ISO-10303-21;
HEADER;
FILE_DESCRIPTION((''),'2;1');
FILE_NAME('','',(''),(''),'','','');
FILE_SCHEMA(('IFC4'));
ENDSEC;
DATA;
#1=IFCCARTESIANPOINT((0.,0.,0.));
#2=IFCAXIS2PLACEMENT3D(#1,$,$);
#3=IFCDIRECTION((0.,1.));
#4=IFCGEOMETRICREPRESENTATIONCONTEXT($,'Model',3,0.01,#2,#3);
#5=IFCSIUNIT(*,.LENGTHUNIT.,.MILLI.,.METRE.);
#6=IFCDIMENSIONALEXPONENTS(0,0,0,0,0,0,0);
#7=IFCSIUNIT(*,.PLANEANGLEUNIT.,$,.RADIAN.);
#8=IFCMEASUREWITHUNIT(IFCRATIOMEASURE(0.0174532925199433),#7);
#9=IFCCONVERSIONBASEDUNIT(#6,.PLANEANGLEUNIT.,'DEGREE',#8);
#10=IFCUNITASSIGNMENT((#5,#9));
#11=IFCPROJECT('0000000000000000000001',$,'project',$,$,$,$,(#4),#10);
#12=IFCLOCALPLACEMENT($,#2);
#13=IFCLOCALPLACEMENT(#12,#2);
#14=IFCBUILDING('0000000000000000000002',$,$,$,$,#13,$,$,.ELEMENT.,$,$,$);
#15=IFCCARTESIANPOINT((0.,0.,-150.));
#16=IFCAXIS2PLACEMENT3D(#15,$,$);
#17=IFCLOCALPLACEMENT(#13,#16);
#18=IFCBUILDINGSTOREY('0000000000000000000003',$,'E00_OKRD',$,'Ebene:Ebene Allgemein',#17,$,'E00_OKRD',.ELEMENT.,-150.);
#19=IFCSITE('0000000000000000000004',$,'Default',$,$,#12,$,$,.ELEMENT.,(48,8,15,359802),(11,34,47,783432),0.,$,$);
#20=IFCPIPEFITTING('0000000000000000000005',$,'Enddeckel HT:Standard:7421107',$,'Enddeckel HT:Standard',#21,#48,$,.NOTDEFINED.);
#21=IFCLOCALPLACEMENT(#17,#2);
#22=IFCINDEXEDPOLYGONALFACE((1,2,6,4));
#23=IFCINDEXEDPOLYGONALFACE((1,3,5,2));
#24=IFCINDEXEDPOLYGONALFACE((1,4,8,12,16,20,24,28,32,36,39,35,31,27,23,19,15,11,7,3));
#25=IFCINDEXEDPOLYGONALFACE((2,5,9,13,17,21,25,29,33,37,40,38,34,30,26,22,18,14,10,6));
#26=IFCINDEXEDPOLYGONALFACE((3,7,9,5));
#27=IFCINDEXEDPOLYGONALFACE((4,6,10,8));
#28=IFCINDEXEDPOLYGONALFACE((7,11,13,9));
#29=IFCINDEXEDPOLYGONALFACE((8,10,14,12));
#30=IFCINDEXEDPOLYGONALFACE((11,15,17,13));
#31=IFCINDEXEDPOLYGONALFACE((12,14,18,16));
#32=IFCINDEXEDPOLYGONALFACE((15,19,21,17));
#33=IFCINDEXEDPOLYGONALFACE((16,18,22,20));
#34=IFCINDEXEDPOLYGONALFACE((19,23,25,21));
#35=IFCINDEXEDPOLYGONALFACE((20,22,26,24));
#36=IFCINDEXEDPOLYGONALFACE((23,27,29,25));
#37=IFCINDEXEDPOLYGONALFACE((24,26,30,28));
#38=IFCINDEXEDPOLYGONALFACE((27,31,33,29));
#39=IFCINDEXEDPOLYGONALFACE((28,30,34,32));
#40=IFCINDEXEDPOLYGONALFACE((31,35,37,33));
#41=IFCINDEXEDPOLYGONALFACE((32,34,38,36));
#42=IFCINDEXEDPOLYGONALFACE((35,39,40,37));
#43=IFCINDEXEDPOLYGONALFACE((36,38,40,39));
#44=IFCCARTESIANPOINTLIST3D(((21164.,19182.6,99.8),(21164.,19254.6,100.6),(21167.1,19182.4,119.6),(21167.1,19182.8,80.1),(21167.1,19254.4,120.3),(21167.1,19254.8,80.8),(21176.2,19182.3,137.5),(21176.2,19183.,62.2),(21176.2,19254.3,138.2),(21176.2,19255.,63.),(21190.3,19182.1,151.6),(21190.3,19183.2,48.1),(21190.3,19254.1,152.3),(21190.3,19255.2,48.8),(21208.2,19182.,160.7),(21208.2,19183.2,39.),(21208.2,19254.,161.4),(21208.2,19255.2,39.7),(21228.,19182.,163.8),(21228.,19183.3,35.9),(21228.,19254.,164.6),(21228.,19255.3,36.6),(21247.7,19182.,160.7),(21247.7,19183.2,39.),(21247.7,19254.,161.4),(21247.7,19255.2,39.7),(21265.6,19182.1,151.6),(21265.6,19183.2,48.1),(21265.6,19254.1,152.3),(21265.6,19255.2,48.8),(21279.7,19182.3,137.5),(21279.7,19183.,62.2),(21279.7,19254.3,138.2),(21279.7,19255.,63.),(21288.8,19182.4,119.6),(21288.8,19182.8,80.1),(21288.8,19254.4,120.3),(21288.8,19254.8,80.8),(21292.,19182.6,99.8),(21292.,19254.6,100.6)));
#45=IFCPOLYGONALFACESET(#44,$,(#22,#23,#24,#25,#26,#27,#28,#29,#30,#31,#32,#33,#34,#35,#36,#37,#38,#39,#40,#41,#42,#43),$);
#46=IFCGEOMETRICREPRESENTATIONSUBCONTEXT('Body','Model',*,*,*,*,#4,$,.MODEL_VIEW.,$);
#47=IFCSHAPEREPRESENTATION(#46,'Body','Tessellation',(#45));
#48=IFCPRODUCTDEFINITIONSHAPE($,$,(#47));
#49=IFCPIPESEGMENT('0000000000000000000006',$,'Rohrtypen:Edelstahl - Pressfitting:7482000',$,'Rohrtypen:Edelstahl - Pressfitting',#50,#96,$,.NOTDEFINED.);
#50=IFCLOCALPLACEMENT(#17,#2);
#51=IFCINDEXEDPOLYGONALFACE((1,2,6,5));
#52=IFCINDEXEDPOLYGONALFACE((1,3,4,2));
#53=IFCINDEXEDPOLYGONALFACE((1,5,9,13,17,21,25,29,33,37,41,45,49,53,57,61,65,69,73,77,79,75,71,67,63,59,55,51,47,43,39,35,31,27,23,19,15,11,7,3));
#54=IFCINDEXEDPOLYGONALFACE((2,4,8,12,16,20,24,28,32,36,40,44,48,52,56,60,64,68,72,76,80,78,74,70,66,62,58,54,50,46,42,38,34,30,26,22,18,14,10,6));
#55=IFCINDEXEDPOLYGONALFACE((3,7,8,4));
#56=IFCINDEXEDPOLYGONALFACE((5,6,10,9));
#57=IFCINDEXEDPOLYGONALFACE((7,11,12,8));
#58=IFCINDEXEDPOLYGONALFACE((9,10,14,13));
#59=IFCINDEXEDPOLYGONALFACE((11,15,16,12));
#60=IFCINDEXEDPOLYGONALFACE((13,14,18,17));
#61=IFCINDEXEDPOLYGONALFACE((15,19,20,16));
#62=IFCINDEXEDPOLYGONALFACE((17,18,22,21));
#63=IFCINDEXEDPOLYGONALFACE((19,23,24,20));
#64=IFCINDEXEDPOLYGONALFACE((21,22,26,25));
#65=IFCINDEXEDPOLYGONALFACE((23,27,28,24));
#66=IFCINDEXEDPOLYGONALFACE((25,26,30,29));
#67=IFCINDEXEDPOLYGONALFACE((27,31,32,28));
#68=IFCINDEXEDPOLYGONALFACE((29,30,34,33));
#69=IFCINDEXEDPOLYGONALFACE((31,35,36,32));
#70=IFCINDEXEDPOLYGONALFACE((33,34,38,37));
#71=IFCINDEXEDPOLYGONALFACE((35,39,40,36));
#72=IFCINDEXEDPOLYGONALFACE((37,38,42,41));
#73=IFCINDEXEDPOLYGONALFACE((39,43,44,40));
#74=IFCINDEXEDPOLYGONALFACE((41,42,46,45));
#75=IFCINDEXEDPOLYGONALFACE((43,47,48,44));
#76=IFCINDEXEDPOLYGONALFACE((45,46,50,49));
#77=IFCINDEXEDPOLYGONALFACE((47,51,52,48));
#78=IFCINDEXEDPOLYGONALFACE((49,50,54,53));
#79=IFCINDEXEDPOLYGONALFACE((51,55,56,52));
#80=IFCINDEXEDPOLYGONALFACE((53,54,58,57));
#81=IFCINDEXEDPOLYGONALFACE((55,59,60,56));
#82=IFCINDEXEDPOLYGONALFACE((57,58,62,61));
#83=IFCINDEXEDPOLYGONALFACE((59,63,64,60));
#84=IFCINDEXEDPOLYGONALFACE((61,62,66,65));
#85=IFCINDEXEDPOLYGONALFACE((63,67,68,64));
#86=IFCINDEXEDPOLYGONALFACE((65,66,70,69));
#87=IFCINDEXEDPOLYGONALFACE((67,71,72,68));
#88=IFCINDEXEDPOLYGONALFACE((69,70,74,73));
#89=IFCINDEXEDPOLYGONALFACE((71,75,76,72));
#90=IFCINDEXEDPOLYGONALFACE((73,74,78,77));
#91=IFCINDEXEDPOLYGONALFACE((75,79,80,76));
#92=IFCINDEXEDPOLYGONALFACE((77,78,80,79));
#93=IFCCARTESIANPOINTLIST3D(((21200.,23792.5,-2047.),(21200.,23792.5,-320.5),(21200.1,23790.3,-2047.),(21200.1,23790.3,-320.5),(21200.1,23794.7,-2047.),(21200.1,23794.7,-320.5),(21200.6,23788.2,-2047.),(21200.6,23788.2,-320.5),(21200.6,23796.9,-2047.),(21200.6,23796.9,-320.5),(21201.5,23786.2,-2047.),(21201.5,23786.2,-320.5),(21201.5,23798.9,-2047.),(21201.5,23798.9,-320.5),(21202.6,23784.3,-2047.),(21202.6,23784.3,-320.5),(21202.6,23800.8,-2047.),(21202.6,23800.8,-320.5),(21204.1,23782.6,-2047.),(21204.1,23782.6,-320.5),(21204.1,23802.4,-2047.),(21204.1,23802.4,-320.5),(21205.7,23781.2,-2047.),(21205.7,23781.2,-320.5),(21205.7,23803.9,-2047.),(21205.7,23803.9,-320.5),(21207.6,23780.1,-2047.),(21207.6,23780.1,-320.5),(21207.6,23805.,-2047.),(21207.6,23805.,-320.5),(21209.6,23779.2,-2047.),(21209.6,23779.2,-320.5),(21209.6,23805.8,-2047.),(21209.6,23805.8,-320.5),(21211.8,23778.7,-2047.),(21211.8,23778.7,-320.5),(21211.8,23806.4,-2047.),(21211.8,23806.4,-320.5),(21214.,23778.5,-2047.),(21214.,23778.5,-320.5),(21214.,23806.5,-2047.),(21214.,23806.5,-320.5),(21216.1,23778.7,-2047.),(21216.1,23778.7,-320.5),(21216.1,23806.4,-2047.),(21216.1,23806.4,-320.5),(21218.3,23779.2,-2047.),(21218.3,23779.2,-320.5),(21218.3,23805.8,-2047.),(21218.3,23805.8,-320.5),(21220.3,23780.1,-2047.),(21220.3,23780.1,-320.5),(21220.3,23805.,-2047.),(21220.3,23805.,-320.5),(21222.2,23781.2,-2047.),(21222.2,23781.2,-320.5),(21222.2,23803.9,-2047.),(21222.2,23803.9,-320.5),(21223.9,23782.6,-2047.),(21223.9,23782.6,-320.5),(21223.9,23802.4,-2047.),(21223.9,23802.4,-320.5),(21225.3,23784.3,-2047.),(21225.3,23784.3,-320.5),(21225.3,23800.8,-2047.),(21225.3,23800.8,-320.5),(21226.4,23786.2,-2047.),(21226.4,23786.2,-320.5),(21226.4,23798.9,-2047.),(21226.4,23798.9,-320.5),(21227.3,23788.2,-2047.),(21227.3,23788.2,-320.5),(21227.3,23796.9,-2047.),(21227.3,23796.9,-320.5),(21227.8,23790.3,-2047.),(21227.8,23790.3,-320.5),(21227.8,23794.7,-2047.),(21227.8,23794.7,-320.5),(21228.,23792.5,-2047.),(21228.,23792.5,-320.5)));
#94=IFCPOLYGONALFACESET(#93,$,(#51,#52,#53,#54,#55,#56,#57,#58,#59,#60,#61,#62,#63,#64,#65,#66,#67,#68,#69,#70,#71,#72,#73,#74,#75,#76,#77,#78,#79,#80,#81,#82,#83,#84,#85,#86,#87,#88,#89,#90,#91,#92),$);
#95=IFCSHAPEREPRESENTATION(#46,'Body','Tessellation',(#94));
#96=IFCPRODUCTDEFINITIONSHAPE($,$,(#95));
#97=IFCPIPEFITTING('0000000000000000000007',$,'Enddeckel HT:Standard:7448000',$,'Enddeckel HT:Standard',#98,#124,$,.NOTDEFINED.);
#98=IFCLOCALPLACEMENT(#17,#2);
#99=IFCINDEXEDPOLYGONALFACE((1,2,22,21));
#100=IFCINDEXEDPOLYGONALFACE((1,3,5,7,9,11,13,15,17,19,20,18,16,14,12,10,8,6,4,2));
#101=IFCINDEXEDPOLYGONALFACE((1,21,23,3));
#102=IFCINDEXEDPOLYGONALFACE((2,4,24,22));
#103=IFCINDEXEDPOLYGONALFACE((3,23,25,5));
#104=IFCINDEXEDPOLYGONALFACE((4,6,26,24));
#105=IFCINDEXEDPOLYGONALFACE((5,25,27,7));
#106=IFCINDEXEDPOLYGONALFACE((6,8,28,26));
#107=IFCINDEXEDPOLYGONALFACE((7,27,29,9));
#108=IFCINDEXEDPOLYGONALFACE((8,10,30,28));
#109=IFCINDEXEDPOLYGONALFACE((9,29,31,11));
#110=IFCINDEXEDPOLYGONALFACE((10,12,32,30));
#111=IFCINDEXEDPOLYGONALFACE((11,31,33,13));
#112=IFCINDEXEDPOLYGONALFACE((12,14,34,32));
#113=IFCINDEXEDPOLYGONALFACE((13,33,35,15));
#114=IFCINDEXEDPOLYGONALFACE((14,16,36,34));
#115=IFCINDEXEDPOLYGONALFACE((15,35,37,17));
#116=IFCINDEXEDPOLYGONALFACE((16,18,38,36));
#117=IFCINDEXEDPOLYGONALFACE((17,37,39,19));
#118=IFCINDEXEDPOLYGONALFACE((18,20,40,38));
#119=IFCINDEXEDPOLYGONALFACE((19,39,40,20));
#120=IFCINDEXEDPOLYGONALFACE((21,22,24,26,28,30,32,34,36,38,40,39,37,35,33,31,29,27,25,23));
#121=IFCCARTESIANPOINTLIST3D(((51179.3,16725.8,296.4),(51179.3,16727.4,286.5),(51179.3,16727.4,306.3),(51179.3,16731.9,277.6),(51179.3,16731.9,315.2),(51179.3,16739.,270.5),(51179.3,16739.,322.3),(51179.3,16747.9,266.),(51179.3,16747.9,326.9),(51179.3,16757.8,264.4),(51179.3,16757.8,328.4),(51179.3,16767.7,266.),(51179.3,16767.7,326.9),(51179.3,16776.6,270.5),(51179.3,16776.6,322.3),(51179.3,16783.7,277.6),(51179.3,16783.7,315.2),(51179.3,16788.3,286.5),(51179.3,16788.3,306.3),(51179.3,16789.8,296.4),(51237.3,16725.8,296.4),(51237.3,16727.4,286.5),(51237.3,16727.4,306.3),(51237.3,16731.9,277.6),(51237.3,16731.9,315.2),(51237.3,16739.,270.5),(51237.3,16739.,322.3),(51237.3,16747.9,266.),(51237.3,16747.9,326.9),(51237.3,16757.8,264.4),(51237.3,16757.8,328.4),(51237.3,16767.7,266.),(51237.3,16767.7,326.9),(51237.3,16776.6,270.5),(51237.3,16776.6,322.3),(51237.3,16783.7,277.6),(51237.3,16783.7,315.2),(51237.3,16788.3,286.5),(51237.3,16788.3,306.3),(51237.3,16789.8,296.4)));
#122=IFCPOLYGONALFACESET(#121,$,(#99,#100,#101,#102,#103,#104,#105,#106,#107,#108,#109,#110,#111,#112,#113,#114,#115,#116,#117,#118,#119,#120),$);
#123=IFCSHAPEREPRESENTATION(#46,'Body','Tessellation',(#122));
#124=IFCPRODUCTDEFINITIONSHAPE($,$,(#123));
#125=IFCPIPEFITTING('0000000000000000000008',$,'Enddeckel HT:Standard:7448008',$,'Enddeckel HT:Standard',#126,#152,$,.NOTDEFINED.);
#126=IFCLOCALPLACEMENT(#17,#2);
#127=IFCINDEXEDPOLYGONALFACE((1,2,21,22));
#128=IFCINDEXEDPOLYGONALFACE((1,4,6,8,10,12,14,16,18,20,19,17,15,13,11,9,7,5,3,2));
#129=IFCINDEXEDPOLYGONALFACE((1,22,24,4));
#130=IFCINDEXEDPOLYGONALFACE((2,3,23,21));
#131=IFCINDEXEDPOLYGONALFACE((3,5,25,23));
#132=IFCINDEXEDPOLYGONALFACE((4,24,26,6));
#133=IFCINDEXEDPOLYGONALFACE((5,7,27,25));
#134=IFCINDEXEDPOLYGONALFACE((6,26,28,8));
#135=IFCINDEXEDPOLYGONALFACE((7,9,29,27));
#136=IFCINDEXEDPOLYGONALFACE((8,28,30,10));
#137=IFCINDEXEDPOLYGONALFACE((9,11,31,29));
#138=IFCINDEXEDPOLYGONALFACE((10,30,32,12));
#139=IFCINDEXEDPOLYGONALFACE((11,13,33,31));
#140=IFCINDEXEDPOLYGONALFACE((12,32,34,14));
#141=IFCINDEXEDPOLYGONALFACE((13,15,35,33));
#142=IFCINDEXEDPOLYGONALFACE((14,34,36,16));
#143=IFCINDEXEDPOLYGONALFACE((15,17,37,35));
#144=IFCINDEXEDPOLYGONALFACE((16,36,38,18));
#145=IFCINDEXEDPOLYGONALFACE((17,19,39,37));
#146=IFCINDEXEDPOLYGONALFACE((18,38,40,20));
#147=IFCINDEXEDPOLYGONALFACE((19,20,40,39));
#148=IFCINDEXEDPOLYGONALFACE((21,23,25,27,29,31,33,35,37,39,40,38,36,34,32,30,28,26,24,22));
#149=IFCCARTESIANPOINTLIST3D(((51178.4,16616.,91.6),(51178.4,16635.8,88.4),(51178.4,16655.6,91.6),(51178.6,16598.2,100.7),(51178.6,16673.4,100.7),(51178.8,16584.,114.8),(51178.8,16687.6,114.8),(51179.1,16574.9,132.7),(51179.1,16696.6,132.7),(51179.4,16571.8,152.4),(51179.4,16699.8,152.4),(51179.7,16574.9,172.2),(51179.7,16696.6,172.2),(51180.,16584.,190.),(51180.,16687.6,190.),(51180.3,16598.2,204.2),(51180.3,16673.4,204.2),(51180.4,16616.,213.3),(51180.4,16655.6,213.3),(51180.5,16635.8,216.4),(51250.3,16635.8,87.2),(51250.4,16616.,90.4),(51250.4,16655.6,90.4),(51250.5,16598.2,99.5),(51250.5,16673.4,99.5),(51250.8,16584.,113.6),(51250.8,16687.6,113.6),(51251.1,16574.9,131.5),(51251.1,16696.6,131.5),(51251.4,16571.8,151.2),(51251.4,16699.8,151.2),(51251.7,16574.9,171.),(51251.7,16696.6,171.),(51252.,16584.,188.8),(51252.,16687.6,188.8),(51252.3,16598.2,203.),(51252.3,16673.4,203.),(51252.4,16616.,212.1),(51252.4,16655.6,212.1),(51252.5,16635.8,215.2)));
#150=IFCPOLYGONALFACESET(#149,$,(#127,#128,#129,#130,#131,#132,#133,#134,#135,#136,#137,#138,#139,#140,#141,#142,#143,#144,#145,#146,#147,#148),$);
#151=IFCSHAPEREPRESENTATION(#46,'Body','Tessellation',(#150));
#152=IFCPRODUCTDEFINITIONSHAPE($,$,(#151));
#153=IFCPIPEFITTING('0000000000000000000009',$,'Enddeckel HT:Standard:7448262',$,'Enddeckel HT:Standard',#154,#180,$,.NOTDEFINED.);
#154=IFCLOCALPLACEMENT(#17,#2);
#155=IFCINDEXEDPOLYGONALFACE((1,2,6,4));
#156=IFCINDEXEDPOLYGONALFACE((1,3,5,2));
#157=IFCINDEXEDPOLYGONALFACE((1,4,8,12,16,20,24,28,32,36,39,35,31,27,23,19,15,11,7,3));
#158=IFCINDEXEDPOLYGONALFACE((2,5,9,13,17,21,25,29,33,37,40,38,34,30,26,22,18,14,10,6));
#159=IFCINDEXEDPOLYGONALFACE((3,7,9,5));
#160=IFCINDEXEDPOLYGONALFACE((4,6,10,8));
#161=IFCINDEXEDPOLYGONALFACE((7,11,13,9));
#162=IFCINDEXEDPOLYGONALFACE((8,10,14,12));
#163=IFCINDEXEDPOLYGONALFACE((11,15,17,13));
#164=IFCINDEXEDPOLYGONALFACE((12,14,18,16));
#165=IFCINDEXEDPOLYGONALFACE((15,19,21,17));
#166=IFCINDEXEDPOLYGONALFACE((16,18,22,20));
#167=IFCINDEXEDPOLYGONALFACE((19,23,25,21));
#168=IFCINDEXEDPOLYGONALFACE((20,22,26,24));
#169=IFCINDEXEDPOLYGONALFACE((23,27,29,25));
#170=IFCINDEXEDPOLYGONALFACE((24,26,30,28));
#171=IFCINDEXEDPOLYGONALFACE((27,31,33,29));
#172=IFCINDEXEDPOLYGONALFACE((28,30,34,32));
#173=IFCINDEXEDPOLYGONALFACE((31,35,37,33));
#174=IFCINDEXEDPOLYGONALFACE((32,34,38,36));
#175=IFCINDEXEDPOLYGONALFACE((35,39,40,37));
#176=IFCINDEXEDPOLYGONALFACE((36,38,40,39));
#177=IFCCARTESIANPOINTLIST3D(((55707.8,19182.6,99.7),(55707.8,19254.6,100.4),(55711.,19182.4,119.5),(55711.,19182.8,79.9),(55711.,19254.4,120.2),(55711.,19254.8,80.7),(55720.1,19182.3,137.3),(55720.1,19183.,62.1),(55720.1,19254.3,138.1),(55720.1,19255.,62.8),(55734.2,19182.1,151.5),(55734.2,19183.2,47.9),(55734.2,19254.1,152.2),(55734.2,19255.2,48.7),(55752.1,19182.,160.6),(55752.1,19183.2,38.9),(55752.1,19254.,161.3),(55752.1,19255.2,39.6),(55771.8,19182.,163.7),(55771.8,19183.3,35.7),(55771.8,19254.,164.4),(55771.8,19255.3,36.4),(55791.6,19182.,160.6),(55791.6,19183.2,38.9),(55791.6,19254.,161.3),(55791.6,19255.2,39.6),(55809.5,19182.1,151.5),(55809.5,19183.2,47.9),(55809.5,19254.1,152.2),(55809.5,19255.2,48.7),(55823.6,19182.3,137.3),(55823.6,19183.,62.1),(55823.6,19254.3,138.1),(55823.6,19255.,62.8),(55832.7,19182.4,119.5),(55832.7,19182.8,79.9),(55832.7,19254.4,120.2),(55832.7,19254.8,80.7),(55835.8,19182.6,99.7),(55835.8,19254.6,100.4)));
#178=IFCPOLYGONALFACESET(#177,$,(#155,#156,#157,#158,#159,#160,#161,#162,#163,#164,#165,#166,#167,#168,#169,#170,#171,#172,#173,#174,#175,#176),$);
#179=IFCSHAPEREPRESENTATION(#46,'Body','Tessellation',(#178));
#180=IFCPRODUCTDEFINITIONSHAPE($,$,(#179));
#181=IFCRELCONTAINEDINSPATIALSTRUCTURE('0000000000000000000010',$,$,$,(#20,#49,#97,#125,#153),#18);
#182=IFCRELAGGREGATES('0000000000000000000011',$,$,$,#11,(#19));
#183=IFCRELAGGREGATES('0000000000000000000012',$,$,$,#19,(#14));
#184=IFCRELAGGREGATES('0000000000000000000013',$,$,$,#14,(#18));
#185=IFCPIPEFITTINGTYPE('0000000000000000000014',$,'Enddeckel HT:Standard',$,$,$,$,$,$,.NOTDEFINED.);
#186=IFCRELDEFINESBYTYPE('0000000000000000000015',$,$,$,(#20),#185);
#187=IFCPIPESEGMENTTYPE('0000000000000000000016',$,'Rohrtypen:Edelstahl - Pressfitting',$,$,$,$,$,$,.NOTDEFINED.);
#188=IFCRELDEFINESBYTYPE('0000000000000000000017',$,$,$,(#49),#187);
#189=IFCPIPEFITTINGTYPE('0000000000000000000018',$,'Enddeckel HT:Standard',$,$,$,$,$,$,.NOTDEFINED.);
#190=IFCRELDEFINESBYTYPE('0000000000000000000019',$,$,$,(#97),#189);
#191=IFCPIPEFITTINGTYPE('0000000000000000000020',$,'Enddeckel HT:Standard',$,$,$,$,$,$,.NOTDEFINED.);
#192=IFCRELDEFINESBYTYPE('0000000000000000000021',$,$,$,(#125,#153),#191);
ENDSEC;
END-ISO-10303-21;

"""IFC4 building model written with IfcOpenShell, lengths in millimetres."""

from ifc_helpers import new_model, entity, si_unit, converted_unit, direction, frame, origin, place, context, subcontext, project, spatial, indexed_curve, outline, extrude, source, transform, mapped, type_object, type_shapes, element, save


model = new_model("IFC4")

# Units and contexts
model_context = context("Model", 3, precision=0.01, world=origin(), true_north=direction((0.0, 1.0)))
body_context = subcontext(model_context, "Body", "Model", "MODEL_VIEW")
ifc_project = project(units=[si_unit("LENGTHUNIT", "METRE", prefix="MILLI"), converted_unit("PLANEANGLEUNIT", "DEGREE", entity("IfcRatioMeasure", 0.0174532925199433), si_unit("PLANEANGLEUNIT", "RADIAN"), dimensions=[0, 0, 0, 0, 0, 0, 0])], contexts=[model_context])

# Site, building, storey
site_placement = place(None, origin())
site = spatial("IfcSite", under=ifc_project, at=site_placement, Name="Default", CompositionType="ELEMENT", RefLatitude=(48, 8, 15, 359802), RefLongitude=(11, 34, 47, 783432), RefElevation=0.0)
building_placement = place(site_placement, origin())
building = spatial("IfcBuilding", under=site, at=building_placement, CompositionType="ELEMENT")
storey_placement = place(building_placement, frame((0.0, 0.0, -150.0)))
storey = spatial("IfcBuildingStorey", under=building, at=storey_placement, Name="E00_OKRD", ObjectType="Ebene:Ebene Allgemein", LongName="E00_OKRD", CompositionType="ELEMENT", Elevation=-150.0)

# Pipe fitting
pipe_fitting_type_1 = type_object("IfcPipeFittingType", Name="Enddeckel HT:Standard", PredefinedType="NOTDEFINED")
shared_shape_1 = source(origin(), body_context, "Body", "SweptSolid", [
    extrude(outline(indexed_curve([(64.0, 0.0), (60.9, 19.8), (51.8, 37.6), (37.6, 51.8), (19.8, 60.9), (0.0, 64.0), (-19.8, 60.9), (-37.6, 51.8), (-51.8, 37.6), (-60.9, 19.8), (-64.0, 0.0), (-60.9, -19.8), (-51.8, -37.6), (-37.6, -51.8), (-19.8, -60.9), (0.0, -64.0), (19.8, -60.9), (37.6, -51.8), (51.8, -37.6), (60.9, -19.8), (64.0, 0.0)], self_intersect=False)), frame((0.0, 0.0, 0.0), z_axis=(1.0, 0.0, 0.0), x_axis=(0.0, 1.0, 0.0)), (0.0, 0.0, 1.0), 72.0),
])
type_shapes(pipe_fitting_type_1, [shared_shape_1])
for number, where, z_axis, x_axis, name in (
    (1, (21228.0, 19182.6, 99.8), (0.0, -0.01, 0.99995), (0.0, 0.99995, 0.01), "Enddeckel HT:Standard:7421107"),
):
    element("IfcPipeFitting", number, at=place(storey_placement, frame(where, z_axis=z_axis, x_axis=x_axis)), inside=storey, type_object=pipe_fitting_type_1, Name=name, ObjectType="Enddeckel HT:Standard", PredefinedType="NOTDEFINED", context=body_context, shape_type="MappedRepresentation", body=[
        mapped(shared_shape_1, transform((0.0, 0.0, 0.0), scale=1.0)),
    ])

# Pipe segment
pipe_segment_type_1 = type_object("IfcPipeSegmentType", Name="Rohrtypen:Edelstahl - Pressfitting", PredefinedType="NOTDEFINED")
pipe_segment_1_placement = place(storey_placement, origin())
element("IfcPipeSegment", 2, at=pipe_segment_1_placement, inside=storey, type_object=pipe_segment_type_1, Name="Rohrtypen:Edelstahl - Pressfitting:7482000", ObjectType="Rohrtypen:Edelstahl - Pressfitting", PredefinedType="NOTDEFINED", context=body_context, shape_type="SweptSolid", body=[
    extrude(outline(indexed_curve([(14.0, 0.0), (13.8, 2.2), (13.3, 4.3), (12.5, 6.4), (11.3, 8.2), (9.9, 9.9), (8.2, 11.3), (6.4, 12.5), (4.3, 13.3), (2.2, 13.8), (0.0, 14.0), (-2.2, 13.8), (-4.3, 13.3), (-6.4, 12.5), (-8.2, 11.3), (-9.9, 9.9), (-11.3, 8.2), (-12.5, 6.4), (-13.3, 4.3), (-13.8, 2.2), (-14.0, 0.0), (-13.8, -2.2), (-13.3, -4.3), (-12.5, -6.4), (-11.3, -8.2), (-9.9, -9.9), (-8.2, -11.3), (-6.4, -12.5), (-4.3, -13.3), (-2.2, -13.8), (0.0, -14.0), (2.2, -13.8), (4.3, -13.3), (6.4, -12.5), (8.2, -11.3), (9.9, -9.9), (11.3, -8.2), (12.5, -6.4), (13.3, -4.3), (13.8, -2.2), (14.0, 0.0)], self_intersect=False)), frame((21214.0, 23792.5, -2047.0)), (0.0, 0.0, 1.0), 1726.5),
])

# Pipe fittings
pipe_fitting_type_2 = type_object("IfcPipeFittingType", Name="Enddeckel HT:Standard", PredefinedType="NOTDEFINED")
shared_shape_2 = source(origin(), body_context, "Body", "SweptSolid", [
    extrude(outline(indexed_curve([(32.0, 0.0), (30.4, 9.9), (25.9, 18.8), (18.8, 25.9), (9.9, 30.4), (0.0, 32.0), (-9.9, 30.4), (-18.8, 25.9), (-25.9, 18.8), (-30.4, 9.9), (-32.0, 0.0), (-30.4, -9.9), (-25.9, -18.8), (-18.8, -25.9), (-9.9, -30.4), (0.0, -32.0), (9.9, -30.4), (18.8, -25.9), (25.9, -18.8), (30.4, -9.9), (32.0, 0.0)], self_intersect=False)), frame((0.0, 0.0, 0.0), z_axis=(1.0, 0.0, 0.0), x_axis=(0.0, -1.0, 0.0)), (0.0, 0.0, 1.0), 58.0),
])
type_shapes(pipe_fitting_type_2, [shared_shape_2])
pipe_fitting_1_placement = place(storey_placement, frame((51237.3, 16757.8, 296.4), z_axis=(0.0, 0.0, 1.0), x_axis=(-1.0, 0.0, 0.0)))
element("IfcPipeFitting", 3, at=pipe_fitting_1_placement, inside=storey, type_object=pipe_fitting_type_2, Name="Enddeckel HT:Standard:7448000", ObjectType="Enddeckel HT:Standard", PredefinedType="NOTDEFINED", context=body_context, shape_type="MappedRepresentation", body=[
    mapped(shared_shape_2, transform((0.0, 0.0, 0.0), scale=1.0)),
])
pipe_fitting_type_3 = type_object("IfcPipeFittingType", Name="Enddeckel HT:Standard", PredefinedType="NOTDEFINED")
shared_shape_3 = source(origin(), body_context, "Body", "SweptSolid", [
    extrude(outline(indexed_curve([(64.0, 0.0), (60.9, 19.8), (51.8, 37.6), (37.6, 51.8), (19.8, 60.9), (0.0, 64.0), (-19.8, 60.9), (-37.6, 51.8), (-51.8, 37.6), (-60.9, 19.8), (-64.0, 0.0), (-60.9, -19.8), (-51.8, -37.6), (-37.6, -51.8), (-19.8, -60.9), (0.0, -64.0), (19.8, -60.9), (37.6, -51.8), (51.8, -37.6), (60.9, -19.8), (64.0, 0.0)], self_intersect=False)), frame((0.0, 0.0, 0.0), z_axis=(1.0, 0.0, 0.0), x_axis=(0.0, -1.0, 0.0)), (0.0, 0.0, 1.0), 72.0),
])
type_shapes(pipe_fitting_type_3, [shared_shape_3])
for number, where, z_axis, x_axis, name in (
    (4, (51251.4, 16635.8, 151.2), (0.016604, 0.0, 0.999862), (-0.999862, 0.0, 0.016604), "Enddeckel HT:Standard:7448008"),
    (5, (55771.8, 19182.6, 99.7), (0.0, -0.01, 0.99995), (0.0, 0.99995, 0.01), "Enddeckel HT:Standard:7448262"),
):
    element("IfcPipeFitting", number, at=place(storey_placement, frame(where, z_axis=z_axis, x_axis=x_axis)), inside=storey, type_object=pipe_fitting_type_3, Name=name, ObjectType="Enddeckel HT:Standard", PredefinedType="NOTDEFINED", context=body_context, shape_type="MappedRepresentation", body=[
        mapped(shared_shape_3, transform((0.0, 0.0, 0.0), scale=1.0)),
    ])

save(model, "model.ifc")
